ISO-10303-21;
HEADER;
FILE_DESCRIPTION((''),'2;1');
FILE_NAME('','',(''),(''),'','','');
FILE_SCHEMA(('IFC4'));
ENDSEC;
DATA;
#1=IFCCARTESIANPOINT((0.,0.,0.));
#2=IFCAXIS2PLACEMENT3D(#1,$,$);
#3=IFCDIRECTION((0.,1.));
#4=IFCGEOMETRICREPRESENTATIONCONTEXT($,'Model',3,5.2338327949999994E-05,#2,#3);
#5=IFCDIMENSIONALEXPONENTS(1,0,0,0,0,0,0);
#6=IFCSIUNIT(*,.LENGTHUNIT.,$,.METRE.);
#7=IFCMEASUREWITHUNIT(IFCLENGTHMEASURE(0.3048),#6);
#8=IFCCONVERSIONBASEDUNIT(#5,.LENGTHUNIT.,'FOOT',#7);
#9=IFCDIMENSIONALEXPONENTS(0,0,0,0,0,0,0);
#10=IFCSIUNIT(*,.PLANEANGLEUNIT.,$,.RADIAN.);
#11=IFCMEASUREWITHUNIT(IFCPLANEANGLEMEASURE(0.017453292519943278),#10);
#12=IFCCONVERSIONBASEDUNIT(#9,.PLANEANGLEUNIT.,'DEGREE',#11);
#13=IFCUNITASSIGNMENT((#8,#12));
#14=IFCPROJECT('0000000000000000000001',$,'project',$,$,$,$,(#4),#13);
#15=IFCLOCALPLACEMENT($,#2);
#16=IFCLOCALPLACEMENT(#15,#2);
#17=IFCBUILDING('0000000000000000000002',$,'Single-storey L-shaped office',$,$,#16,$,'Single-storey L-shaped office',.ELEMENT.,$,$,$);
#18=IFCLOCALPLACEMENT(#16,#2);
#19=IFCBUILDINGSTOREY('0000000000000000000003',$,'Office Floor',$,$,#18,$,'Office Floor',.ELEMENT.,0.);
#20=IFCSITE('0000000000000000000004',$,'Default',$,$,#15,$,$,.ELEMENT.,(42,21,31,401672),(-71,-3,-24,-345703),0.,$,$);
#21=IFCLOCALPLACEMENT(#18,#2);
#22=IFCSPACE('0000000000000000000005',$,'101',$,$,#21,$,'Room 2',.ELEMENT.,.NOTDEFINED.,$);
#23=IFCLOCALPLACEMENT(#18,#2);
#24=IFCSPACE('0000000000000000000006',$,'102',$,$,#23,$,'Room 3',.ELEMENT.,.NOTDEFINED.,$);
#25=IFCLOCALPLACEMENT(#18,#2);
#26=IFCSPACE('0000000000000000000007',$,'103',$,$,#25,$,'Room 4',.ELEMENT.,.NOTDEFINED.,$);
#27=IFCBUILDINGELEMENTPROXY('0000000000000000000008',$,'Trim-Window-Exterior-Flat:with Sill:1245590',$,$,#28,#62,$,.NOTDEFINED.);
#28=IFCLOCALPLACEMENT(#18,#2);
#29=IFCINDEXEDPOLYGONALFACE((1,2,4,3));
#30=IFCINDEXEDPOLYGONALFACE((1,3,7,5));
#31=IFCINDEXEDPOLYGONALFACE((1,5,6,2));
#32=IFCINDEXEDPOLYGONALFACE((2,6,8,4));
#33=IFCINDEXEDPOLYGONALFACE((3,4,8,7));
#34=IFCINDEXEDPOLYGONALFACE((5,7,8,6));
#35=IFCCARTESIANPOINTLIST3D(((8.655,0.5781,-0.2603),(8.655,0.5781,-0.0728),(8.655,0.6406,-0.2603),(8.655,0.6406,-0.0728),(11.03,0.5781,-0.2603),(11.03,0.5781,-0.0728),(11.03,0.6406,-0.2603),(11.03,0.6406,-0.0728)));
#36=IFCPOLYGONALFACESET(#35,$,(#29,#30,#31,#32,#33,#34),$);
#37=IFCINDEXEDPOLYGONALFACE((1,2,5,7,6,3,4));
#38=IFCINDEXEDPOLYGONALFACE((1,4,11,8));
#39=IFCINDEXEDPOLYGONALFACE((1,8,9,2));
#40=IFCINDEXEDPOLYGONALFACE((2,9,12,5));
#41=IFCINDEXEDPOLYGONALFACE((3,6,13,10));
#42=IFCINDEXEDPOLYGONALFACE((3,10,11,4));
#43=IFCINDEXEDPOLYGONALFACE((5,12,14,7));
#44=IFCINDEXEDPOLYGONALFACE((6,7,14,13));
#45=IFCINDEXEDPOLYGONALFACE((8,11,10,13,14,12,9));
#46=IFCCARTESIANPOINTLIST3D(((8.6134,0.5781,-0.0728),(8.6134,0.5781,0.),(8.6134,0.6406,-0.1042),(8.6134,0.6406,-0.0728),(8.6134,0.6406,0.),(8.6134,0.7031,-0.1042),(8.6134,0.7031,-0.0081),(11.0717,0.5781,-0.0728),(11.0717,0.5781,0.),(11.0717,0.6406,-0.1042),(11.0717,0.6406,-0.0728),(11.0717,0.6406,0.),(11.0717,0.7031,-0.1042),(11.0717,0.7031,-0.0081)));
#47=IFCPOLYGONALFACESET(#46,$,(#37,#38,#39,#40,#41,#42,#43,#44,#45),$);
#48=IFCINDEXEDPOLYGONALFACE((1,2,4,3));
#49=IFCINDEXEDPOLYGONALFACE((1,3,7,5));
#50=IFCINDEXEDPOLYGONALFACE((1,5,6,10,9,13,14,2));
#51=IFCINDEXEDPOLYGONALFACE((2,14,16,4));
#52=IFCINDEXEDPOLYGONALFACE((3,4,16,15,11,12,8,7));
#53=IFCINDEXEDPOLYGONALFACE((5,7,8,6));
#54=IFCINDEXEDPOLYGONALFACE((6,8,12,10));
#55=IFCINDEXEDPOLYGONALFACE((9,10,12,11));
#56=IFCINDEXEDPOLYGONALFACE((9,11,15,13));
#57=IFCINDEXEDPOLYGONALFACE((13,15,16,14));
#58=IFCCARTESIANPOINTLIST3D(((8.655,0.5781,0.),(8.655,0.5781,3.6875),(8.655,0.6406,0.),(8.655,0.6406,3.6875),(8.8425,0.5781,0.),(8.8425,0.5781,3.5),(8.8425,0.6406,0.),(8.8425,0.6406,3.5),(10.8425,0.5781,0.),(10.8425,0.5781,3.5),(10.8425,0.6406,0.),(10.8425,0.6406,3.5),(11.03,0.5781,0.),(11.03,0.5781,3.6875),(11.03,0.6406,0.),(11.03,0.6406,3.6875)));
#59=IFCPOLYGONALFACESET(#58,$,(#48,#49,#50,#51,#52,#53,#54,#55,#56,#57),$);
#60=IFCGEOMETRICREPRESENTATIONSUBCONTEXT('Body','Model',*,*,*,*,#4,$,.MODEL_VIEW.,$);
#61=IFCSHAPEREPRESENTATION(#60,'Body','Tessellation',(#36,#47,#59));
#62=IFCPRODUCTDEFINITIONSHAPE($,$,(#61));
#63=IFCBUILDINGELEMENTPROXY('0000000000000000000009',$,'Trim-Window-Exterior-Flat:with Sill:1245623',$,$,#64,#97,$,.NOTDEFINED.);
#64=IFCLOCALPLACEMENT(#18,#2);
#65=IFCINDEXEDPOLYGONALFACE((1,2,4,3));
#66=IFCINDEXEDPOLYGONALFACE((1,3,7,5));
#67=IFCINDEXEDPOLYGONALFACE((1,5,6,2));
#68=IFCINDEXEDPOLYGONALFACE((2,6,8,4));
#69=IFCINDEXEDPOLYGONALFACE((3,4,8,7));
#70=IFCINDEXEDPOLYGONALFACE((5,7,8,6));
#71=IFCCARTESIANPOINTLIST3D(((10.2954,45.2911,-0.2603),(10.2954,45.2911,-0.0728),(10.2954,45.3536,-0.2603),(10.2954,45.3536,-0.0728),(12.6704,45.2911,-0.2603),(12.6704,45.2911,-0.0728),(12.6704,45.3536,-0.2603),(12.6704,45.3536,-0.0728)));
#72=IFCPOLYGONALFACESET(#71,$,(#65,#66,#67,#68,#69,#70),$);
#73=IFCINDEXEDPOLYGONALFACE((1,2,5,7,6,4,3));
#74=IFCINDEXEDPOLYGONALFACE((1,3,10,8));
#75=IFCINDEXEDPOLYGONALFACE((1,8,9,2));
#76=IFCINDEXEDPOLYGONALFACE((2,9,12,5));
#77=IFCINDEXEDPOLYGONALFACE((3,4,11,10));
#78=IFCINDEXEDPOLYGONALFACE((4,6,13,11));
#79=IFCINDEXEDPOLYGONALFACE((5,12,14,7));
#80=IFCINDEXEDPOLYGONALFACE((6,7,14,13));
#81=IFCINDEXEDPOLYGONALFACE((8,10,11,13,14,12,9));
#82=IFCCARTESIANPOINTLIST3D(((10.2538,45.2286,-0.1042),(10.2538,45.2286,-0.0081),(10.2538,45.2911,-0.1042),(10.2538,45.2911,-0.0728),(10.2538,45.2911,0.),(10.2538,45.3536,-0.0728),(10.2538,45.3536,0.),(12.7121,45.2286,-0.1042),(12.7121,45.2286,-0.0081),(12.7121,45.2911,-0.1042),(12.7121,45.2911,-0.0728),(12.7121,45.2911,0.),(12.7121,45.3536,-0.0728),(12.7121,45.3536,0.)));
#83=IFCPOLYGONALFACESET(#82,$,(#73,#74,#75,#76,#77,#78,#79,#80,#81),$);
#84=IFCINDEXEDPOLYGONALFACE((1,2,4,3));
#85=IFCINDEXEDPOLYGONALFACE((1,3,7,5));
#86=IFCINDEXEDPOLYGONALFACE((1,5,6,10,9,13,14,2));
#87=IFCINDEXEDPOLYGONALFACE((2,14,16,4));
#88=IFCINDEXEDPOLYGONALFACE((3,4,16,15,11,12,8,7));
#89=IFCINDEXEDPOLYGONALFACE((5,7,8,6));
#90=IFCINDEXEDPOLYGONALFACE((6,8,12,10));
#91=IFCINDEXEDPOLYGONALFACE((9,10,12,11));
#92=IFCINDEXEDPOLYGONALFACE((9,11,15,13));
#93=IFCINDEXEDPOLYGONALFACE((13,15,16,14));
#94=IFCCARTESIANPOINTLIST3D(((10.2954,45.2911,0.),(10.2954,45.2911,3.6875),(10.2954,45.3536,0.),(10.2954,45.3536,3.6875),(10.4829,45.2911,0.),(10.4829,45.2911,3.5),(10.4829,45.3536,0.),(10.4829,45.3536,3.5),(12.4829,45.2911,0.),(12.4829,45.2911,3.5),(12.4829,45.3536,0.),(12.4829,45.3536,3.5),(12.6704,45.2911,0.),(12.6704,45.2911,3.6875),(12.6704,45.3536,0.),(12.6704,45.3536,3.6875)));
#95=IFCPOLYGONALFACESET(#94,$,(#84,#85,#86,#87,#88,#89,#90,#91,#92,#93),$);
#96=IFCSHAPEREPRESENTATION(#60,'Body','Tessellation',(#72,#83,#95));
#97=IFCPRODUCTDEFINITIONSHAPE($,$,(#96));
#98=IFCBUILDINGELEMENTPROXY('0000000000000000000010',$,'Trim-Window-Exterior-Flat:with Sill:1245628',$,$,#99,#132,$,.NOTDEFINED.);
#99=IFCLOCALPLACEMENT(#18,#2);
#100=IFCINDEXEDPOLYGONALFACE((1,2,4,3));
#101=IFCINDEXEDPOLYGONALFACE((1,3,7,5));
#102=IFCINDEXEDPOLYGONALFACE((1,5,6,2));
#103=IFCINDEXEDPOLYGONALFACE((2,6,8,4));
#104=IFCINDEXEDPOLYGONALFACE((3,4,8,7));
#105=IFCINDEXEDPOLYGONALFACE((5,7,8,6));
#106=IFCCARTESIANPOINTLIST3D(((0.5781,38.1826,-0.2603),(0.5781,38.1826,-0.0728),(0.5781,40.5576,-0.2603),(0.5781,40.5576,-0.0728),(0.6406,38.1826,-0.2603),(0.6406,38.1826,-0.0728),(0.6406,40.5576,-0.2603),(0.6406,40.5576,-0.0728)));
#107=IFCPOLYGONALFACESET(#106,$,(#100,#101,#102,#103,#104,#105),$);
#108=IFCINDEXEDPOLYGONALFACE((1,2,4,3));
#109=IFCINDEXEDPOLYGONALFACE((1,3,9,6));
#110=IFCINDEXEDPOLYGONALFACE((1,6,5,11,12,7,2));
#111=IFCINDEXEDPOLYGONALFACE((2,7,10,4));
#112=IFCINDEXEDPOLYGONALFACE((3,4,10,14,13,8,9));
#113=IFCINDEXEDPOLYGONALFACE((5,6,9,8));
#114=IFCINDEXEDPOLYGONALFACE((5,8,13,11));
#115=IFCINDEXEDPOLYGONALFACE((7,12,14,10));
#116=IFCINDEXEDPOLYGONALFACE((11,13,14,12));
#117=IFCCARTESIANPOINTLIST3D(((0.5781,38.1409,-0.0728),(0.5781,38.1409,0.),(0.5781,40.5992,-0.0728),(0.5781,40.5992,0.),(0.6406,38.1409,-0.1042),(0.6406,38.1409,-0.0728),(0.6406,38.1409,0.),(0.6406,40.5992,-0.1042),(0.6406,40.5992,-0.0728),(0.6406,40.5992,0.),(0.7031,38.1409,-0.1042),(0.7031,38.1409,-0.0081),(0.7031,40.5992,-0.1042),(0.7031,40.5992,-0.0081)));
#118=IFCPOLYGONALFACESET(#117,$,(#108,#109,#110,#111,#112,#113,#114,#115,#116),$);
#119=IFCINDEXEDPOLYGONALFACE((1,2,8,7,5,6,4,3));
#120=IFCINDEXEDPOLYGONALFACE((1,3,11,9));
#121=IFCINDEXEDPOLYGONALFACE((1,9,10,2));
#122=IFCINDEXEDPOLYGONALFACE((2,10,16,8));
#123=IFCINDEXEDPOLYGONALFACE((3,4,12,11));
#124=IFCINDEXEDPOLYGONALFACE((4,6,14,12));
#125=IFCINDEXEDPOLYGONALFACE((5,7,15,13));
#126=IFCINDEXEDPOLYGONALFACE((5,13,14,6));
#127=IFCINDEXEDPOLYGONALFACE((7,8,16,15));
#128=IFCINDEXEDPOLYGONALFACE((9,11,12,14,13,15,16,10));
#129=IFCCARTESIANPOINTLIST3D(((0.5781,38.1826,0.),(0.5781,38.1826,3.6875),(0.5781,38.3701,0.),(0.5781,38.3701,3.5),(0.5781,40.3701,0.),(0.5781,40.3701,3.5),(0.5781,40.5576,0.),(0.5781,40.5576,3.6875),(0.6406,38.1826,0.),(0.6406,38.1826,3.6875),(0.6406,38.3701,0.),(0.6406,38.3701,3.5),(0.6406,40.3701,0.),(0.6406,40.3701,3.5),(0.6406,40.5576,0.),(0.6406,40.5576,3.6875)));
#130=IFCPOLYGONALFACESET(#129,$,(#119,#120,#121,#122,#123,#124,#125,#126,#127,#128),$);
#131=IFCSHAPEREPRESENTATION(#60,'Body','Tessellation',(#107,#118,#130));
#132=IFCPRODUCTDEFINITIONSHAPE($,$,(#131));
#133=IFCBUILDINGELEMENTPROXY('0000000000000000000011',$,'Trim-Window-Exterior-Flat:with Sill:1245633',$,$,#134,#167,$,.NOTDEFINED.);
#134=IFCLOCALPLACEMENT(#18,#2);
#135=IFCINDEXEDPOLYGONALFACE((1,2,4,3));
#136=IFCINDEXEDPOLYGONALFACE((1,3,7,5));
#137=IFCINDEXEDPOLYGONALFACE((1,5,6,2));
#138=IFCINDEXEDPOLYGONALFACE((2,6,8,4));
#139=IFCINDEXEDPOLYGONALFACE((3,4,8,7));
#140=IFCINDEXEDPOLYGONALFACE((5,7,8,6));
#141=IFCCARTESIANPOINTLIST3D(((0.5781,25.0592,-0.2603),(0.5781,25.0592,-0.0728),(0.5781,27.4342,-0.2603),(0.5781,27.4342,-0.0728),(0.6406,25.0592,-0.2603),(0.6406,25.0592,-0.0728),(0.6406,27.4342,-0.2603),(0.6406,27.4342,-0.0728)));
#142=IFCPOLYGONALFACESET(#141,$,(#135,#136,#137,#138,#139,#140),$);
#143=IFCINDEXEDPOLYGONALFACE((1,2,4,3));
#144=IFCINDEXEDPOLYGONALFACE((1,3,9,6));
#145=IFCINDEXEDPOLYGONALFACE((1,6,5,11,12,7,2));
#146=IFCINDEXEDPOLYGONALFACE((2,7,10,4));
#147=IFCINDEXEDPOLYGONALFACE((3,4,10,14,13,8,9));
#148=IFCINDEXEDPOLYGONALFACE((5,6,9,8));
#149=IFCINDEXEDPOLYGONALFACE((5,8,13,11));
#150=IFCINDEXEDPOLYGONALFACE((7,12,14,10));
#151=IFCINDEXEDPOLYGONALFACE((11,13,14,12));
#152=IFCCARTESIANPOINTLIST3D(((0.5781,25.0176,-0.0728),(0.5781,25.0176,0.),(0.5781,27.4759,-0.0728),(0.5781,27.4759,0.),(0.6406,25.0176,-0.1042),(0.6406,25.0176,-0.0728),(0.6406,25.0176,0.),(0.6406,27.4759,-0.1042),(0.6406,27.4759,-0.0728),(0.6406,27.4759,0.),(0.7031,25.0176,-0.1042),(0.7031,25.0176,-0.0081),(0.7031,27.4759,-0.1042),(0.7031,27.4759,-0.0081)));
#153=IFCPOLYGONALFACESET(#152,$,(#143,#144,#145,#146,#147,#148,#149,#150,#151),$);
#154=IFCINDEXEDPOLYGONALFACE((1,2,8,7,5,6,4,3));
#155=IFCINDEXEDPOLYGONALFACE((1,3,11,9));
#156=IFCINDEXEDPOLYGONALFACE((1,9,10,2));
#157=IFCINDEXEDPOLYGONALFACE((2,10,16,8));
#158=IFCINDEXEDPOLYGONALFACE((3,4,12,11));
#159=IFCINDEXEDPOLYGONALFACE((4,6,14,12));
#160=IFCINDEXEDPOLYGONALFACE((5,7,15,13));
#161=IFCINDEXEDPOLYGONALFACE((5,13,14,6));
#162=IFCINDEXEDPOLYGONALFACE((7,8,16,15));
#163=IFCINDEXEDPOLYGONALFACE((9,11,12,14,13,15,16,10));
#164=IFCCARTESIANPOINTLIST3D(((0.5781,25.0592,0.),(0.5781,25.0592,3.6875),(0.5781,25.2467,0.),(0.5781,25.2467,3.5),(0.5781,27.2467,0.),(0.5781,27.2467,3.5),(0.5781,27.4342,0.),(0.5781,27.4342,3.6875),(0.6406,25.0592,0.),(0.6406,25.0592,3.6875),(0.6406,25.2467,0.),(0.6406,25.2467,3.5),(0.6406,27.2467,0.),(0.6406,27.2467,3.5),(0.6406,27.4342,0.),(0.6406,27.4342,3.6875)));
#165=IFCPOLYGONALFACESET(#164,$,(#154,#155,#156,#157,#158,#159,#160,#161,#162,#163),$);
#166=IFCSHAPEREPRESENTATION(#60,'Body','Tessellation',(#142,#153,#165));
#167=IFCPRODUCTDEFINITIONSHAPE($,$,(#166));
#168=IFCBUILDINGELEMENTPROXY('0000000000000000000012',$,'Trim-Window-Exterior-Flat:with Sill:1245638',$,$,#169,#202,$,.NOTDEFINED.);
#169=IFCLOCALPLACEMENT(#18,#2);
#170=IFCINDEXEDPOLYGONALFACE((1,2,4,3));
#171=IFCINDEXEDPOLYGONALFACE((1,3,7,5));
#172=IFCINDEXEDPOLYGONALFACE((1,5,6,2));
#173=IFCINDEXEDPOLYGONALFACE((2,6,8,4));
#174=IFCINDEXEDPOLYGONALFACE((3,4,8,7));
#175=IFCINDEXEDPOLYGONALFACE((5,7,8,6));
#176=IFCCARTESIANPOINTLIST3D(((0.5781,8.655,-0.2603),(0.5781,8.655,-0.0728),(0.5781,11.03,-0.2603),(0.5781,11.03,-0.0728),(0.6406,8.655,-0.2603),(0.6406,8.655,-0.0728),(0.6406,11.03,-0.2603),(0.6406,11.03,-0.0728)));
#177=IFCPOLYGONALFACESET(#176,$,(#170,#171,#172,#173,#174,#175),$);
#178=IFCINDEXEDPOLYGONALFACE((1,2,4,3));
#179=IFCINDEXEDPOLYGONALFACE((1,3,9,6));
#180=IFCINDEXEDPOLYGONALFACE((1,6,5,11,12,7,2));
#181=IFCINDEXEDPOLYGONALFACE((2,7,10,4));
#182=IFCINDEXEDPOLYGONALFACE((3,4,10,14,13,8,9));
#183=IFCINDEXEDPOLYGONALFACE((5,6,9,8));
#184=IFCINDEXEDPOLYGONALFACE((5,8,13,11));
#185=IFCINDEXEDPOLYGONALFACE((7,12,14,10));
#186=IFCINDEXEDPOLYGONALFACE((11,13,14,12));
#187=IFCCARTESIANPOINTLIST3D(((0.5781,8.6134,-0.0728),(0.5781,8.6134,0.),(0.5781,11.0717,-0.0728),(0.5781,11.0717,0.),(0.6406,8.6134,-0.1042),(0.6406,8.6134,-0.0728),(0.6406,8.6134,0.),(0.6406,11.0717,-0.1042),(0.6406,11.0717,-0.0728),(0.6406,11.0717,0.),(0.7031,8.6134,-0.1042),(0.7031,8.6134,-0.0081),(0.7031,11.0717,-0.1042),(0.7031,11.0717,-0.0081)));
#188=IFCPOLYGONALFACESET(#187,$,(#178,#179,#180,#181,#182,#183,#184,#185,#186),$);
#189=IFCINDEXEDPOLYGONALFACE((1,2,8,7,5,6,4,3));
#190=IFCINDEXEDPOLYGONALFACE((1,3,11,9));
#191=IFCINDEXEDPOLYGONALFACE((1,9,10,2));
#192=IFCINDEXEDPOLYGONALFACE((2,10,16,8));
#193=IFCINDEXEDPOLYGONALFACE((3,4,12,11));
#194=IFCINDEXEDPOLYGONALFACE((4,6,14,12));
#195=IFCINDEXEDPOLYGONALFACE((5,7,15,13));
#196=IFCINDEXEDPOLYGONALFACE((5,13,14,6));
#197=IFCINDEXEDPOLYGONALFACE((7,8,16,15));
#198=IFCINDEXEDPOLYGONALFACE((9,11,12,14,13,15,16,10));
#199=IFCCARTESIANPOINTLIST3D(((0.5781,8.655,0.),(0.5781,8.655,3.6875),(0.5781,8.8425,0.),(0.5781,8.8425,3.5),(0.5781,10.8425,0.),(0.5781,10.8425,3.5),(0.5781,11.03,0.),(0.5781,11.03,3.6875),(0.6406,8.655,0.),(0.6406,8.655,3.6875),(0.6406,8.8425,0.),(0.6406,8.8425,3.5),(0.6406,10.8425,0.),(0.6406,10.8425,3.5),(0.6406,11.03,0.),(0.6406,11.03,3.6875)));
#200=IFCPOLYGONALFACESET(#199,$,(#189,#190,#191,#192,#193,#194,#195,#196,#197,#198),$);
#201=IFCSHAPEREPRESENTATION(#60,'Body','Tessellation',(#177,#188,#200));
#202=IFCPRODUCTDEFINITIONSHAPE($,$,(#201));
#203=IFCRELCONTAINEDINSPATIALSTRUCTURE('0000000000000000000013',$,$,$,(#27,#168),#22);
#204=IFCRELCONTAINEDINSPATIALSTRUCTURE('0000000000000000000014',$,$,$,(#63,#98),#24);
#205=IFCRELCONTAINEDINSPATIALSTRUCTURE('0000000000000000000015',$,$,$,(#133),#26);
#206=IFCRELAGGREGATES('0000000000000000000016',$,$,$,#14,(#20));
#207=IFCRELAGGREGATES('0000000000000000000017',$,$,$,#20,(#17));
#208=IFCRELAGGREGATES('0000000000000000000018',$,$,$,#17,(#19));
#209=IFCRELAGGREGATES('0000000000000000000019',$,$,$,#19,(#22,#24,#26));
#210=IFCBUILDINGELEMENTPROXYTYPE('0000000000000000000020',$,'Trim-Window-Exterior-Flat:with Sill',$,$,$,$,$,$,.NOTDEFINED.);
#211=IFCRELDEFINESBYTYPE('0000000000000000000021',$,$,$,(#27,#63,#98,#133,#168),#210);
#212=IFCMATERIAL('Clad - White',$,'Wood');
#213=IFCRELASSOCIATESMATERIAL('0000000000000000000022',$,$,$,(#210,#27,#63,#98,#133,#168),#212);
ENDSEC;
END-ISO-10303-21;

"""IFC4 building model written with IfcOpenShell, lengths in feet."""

from ifc_helpers import new_model, entity, si_unit, converted_unit, direction, frame, origin, place, context, subcontext, project, spatial, indexed_curve, outline, extrude, source, transform, mapped, material, type_object, type_shapes, element, save


model = new_model("IFC4")

# Units and contexts
model_context = context("Model", 3, precision=5.2338327949999994e-05, world=origin(), true_north=direction((0.0, 1.0)))
body_context = subcontext(model_context, "Body", "Model", "MODEL_VIEW")
ifc_project = project(units=[converted_unit("LENGTHUNIT", "FOOT", entity("IfcLengthMeasure", 0.3048), si_unit("LENGTHUNIT", "METRE"), dimensions=[1, 0, 0, 0, 0, 0, 0]), converted_unit("PLANEANGLEUNIT", "DEGREE", entity("IfcPlaneAngleMeasure", 0.017453292519943278), si_unit("PLANEANGLEUNIT", "RADIAN"), dimensions=[0, 0, 0, 0, 0, 0, 0])], contexts=[model_context])

# Site, building, storey
site_placement = place(None, origin())
site = spatial("IfcSite", under=ifc_project, at=site_placement, Name="Default", CompositionType="ELEMENT", RefLatitude=(42, 21, 31, 401672), RefLongitude=(-71, -3, -24, -345703), RefElevation=0.0)
building_placement = place(site_placement, origin())
building = spatial("IfcBuilding", under=site, at=building_placement, Name="Single-storey L-shaped office", LongName="Single-storey L-shaped office", CompositionType="ELEMENT")
storey_placement = place(building_placement, origin())
storey = spatial("IfcBuildingStorey", under=building, at=storey_placement, Name="Office Floor", LongName="Office Floor", CompositionType="ELEMENT", Elevation=0.0)

# Shared definitions
ifc_material_1 = material(Name="Clad - White", Category="Wood")

# Shared definitions
space_1_placement = place(storey_placement, origin())
space_1 = spatial("IfcSpace", under=storey, at=space_1_placement, Name="101", LongName="Room 2", CompositionType="ELEMENT", PredefinedType="NOTDEFINED")

# Building element proxy
building_element_proxy_type_1 = type_object("IfcBuildingElementProxyType", Name="Trim-Window-Exterior-Flat:with Sill", PredefinedType="NOTDEFINED", material=ifc_material_1)
shared_shape_1 = source(origin(), body_context, "Body", "SweptSolid", [
    extrude(outline(indexed_curve([(-1.1875, -0.0938), (1.1875, -0.0938), (1.1875, 0.0938), (-1.1875, 0.0938), (-1.1875, -0.0938)], self_intersect=False)), frame((0.0, -3.6665, 0.0), z_axis=(0.0, 0.0, 1.0), x_axis=(-1.0, 0.0, 0.0)), (0.0, 0.0, 1.0), 0.0625),
    extrude(outline(indexed_curve([(-0.0625, -0.0525), (0.0, -0.0525), (0.0, -0.0211), (0.0625, -0.0211), (0.0625, 0.0517), (0.0, 0.0517), (-0.0625, 0.0436), (-0.0625, -0.0525)], self_intersect=False)), frame((-1.2292, -3.5517, 0.0625), z_axis=(1.0, 0.0, 0.0), x_axis=(0.0, 0.0, -1.0)), (0.0, 0.0, 1.0), 2.4583),
    extrude(outline(indexed_curve([(-1.8906, -1.1875), (1.7969, -1.1875), (1.7969, -1.0), (-1.7031, -1.0), (-1.7031, 1.0), (1.7969, 1.0), (1.7969, 1.1875), (-1.8906, 1.1875), (-1.8906, -1.1875)], self_intersect=False)), frame((0.0, -1.7031, 0.0), z_axis=(0.0, 0.0, 1.0), x_axis=(0.0, -1.0, 0.0)), (0.0, 0.0, 1.0), 0.0625),
])
type_shapes(building_element_proxy_type_1, [shared_shape_1])
proxy_1_placement = place(space_1_placement, frame((9.8425, 0.5781, 3.5), z_axis=(0.0, 1.0, 0.0), x_axis=(-1.0, 0.0, 0.0)))
element("IfcBuildingElementProxy", 1, at=proxy_1_placement, inside=space_1, type_object=building_element_proxy_type_1, material=ifc_material_1, Name="Trim-Window-Exterior-Flat:with Sill:1245590", PredefinedType="NOTDEFINED", context=body_context, shape_type="MappedRepresentation", body=[
    mapped(shared_shape_1, transform((0.0, 0.0, 0.0), scale=1.0)),
])

# Shared definitions
space_2_placement = place(storey_placement, origin())
space_2 = spatial("IfcSpace", under=storey, at=space_2_placement, Name="102", LongName="Room 3", CompositionType="ELEMENT", PredefinedType="NOTDEFINED")

# Building element proxies
for number, where, z_axis, x_axis, name in (
    (2, (11.4829, 45.3536, 3.5), (0.0, -1.0, 0.0), (1.0, 0.0, 0.0), "Trim-Window-Exterior-Flat:with Sill:1245623"),
    (3, (0.5781, 39.3701, 3.5), (1.0, 0.0, 0.0), (0.0, 1.0, 0.0), "Trim-Window-Exterior-Flat:with Sill:1245628"),
):
    element("IfcBuildingElementProxy", number, at=place(space_2_placement, frame(where, z_axis=z_axis, x_axis=x_axis)), inside=space_2, type_object=building_element_proxy_type_1, material=ifc_material_1, Name=name, PredefinedType="NOTDEFINED", context=body_context, shape_type="MappedRepresentation", body=[
        mapped(shared_shape_1, transform((0.0, 0.0, 0.0), scale=1.0)),
    ])

# Shared definitions
space_3_placement = place(storey_placement, origin())
space_3 = spatial("IfcSpace", under=storey, at=space_3_placement, Name="103", LongName="Room 4", CompositionType="ELEMENT", PredefinedType="NOTDEFINED")

# Building element proxies
proxy_2_placement = place(space_3_placement, frame((0.5781, 26.2467, 3.5), z_axis=(1.0, 0.0, 0.0), x_axis=(0.0, 1.0, 0.0)))
element("IfcBuildingElementProxy", 4, at=proxy_2_placement, inside=space_3, type_object=building_element_proxy_type_1, material=ifc_material_1, Name="Trim-Window-Exterior-Flat:with Sill:1245633", PredefinedType="NOTDEFINED", context=body_context, shape_type="MappedRepresentation", body=[
    mapped(shared_shape_1, transform((0.0, 0.0, 0.0), scale=1.0)),
])
proxy_3_placement = place(space_1_placement, frame((0.5781, 9.8425, 3.5), z_axis=(1.0, 0.0, 0.0), x_axis=(0.0, 1.0, 0.0)))
element("IfcBuildingElementProxy", 5, at=proxy_3_placement, inside=space_1, type_object=building_element_proxy_type_1, material=ifc_material_1, Name="Trim-Window-Exterior-Flat:with Sill:1245638", PredefinedType="NOTDEFINED", context=body_context, shape_type="MappedRepresentation", body=[
    mapped(shared_shape_1, transform((0.0, 0.0, 0.0), scale=1.0)),
])

save(model, "model.ifc")
